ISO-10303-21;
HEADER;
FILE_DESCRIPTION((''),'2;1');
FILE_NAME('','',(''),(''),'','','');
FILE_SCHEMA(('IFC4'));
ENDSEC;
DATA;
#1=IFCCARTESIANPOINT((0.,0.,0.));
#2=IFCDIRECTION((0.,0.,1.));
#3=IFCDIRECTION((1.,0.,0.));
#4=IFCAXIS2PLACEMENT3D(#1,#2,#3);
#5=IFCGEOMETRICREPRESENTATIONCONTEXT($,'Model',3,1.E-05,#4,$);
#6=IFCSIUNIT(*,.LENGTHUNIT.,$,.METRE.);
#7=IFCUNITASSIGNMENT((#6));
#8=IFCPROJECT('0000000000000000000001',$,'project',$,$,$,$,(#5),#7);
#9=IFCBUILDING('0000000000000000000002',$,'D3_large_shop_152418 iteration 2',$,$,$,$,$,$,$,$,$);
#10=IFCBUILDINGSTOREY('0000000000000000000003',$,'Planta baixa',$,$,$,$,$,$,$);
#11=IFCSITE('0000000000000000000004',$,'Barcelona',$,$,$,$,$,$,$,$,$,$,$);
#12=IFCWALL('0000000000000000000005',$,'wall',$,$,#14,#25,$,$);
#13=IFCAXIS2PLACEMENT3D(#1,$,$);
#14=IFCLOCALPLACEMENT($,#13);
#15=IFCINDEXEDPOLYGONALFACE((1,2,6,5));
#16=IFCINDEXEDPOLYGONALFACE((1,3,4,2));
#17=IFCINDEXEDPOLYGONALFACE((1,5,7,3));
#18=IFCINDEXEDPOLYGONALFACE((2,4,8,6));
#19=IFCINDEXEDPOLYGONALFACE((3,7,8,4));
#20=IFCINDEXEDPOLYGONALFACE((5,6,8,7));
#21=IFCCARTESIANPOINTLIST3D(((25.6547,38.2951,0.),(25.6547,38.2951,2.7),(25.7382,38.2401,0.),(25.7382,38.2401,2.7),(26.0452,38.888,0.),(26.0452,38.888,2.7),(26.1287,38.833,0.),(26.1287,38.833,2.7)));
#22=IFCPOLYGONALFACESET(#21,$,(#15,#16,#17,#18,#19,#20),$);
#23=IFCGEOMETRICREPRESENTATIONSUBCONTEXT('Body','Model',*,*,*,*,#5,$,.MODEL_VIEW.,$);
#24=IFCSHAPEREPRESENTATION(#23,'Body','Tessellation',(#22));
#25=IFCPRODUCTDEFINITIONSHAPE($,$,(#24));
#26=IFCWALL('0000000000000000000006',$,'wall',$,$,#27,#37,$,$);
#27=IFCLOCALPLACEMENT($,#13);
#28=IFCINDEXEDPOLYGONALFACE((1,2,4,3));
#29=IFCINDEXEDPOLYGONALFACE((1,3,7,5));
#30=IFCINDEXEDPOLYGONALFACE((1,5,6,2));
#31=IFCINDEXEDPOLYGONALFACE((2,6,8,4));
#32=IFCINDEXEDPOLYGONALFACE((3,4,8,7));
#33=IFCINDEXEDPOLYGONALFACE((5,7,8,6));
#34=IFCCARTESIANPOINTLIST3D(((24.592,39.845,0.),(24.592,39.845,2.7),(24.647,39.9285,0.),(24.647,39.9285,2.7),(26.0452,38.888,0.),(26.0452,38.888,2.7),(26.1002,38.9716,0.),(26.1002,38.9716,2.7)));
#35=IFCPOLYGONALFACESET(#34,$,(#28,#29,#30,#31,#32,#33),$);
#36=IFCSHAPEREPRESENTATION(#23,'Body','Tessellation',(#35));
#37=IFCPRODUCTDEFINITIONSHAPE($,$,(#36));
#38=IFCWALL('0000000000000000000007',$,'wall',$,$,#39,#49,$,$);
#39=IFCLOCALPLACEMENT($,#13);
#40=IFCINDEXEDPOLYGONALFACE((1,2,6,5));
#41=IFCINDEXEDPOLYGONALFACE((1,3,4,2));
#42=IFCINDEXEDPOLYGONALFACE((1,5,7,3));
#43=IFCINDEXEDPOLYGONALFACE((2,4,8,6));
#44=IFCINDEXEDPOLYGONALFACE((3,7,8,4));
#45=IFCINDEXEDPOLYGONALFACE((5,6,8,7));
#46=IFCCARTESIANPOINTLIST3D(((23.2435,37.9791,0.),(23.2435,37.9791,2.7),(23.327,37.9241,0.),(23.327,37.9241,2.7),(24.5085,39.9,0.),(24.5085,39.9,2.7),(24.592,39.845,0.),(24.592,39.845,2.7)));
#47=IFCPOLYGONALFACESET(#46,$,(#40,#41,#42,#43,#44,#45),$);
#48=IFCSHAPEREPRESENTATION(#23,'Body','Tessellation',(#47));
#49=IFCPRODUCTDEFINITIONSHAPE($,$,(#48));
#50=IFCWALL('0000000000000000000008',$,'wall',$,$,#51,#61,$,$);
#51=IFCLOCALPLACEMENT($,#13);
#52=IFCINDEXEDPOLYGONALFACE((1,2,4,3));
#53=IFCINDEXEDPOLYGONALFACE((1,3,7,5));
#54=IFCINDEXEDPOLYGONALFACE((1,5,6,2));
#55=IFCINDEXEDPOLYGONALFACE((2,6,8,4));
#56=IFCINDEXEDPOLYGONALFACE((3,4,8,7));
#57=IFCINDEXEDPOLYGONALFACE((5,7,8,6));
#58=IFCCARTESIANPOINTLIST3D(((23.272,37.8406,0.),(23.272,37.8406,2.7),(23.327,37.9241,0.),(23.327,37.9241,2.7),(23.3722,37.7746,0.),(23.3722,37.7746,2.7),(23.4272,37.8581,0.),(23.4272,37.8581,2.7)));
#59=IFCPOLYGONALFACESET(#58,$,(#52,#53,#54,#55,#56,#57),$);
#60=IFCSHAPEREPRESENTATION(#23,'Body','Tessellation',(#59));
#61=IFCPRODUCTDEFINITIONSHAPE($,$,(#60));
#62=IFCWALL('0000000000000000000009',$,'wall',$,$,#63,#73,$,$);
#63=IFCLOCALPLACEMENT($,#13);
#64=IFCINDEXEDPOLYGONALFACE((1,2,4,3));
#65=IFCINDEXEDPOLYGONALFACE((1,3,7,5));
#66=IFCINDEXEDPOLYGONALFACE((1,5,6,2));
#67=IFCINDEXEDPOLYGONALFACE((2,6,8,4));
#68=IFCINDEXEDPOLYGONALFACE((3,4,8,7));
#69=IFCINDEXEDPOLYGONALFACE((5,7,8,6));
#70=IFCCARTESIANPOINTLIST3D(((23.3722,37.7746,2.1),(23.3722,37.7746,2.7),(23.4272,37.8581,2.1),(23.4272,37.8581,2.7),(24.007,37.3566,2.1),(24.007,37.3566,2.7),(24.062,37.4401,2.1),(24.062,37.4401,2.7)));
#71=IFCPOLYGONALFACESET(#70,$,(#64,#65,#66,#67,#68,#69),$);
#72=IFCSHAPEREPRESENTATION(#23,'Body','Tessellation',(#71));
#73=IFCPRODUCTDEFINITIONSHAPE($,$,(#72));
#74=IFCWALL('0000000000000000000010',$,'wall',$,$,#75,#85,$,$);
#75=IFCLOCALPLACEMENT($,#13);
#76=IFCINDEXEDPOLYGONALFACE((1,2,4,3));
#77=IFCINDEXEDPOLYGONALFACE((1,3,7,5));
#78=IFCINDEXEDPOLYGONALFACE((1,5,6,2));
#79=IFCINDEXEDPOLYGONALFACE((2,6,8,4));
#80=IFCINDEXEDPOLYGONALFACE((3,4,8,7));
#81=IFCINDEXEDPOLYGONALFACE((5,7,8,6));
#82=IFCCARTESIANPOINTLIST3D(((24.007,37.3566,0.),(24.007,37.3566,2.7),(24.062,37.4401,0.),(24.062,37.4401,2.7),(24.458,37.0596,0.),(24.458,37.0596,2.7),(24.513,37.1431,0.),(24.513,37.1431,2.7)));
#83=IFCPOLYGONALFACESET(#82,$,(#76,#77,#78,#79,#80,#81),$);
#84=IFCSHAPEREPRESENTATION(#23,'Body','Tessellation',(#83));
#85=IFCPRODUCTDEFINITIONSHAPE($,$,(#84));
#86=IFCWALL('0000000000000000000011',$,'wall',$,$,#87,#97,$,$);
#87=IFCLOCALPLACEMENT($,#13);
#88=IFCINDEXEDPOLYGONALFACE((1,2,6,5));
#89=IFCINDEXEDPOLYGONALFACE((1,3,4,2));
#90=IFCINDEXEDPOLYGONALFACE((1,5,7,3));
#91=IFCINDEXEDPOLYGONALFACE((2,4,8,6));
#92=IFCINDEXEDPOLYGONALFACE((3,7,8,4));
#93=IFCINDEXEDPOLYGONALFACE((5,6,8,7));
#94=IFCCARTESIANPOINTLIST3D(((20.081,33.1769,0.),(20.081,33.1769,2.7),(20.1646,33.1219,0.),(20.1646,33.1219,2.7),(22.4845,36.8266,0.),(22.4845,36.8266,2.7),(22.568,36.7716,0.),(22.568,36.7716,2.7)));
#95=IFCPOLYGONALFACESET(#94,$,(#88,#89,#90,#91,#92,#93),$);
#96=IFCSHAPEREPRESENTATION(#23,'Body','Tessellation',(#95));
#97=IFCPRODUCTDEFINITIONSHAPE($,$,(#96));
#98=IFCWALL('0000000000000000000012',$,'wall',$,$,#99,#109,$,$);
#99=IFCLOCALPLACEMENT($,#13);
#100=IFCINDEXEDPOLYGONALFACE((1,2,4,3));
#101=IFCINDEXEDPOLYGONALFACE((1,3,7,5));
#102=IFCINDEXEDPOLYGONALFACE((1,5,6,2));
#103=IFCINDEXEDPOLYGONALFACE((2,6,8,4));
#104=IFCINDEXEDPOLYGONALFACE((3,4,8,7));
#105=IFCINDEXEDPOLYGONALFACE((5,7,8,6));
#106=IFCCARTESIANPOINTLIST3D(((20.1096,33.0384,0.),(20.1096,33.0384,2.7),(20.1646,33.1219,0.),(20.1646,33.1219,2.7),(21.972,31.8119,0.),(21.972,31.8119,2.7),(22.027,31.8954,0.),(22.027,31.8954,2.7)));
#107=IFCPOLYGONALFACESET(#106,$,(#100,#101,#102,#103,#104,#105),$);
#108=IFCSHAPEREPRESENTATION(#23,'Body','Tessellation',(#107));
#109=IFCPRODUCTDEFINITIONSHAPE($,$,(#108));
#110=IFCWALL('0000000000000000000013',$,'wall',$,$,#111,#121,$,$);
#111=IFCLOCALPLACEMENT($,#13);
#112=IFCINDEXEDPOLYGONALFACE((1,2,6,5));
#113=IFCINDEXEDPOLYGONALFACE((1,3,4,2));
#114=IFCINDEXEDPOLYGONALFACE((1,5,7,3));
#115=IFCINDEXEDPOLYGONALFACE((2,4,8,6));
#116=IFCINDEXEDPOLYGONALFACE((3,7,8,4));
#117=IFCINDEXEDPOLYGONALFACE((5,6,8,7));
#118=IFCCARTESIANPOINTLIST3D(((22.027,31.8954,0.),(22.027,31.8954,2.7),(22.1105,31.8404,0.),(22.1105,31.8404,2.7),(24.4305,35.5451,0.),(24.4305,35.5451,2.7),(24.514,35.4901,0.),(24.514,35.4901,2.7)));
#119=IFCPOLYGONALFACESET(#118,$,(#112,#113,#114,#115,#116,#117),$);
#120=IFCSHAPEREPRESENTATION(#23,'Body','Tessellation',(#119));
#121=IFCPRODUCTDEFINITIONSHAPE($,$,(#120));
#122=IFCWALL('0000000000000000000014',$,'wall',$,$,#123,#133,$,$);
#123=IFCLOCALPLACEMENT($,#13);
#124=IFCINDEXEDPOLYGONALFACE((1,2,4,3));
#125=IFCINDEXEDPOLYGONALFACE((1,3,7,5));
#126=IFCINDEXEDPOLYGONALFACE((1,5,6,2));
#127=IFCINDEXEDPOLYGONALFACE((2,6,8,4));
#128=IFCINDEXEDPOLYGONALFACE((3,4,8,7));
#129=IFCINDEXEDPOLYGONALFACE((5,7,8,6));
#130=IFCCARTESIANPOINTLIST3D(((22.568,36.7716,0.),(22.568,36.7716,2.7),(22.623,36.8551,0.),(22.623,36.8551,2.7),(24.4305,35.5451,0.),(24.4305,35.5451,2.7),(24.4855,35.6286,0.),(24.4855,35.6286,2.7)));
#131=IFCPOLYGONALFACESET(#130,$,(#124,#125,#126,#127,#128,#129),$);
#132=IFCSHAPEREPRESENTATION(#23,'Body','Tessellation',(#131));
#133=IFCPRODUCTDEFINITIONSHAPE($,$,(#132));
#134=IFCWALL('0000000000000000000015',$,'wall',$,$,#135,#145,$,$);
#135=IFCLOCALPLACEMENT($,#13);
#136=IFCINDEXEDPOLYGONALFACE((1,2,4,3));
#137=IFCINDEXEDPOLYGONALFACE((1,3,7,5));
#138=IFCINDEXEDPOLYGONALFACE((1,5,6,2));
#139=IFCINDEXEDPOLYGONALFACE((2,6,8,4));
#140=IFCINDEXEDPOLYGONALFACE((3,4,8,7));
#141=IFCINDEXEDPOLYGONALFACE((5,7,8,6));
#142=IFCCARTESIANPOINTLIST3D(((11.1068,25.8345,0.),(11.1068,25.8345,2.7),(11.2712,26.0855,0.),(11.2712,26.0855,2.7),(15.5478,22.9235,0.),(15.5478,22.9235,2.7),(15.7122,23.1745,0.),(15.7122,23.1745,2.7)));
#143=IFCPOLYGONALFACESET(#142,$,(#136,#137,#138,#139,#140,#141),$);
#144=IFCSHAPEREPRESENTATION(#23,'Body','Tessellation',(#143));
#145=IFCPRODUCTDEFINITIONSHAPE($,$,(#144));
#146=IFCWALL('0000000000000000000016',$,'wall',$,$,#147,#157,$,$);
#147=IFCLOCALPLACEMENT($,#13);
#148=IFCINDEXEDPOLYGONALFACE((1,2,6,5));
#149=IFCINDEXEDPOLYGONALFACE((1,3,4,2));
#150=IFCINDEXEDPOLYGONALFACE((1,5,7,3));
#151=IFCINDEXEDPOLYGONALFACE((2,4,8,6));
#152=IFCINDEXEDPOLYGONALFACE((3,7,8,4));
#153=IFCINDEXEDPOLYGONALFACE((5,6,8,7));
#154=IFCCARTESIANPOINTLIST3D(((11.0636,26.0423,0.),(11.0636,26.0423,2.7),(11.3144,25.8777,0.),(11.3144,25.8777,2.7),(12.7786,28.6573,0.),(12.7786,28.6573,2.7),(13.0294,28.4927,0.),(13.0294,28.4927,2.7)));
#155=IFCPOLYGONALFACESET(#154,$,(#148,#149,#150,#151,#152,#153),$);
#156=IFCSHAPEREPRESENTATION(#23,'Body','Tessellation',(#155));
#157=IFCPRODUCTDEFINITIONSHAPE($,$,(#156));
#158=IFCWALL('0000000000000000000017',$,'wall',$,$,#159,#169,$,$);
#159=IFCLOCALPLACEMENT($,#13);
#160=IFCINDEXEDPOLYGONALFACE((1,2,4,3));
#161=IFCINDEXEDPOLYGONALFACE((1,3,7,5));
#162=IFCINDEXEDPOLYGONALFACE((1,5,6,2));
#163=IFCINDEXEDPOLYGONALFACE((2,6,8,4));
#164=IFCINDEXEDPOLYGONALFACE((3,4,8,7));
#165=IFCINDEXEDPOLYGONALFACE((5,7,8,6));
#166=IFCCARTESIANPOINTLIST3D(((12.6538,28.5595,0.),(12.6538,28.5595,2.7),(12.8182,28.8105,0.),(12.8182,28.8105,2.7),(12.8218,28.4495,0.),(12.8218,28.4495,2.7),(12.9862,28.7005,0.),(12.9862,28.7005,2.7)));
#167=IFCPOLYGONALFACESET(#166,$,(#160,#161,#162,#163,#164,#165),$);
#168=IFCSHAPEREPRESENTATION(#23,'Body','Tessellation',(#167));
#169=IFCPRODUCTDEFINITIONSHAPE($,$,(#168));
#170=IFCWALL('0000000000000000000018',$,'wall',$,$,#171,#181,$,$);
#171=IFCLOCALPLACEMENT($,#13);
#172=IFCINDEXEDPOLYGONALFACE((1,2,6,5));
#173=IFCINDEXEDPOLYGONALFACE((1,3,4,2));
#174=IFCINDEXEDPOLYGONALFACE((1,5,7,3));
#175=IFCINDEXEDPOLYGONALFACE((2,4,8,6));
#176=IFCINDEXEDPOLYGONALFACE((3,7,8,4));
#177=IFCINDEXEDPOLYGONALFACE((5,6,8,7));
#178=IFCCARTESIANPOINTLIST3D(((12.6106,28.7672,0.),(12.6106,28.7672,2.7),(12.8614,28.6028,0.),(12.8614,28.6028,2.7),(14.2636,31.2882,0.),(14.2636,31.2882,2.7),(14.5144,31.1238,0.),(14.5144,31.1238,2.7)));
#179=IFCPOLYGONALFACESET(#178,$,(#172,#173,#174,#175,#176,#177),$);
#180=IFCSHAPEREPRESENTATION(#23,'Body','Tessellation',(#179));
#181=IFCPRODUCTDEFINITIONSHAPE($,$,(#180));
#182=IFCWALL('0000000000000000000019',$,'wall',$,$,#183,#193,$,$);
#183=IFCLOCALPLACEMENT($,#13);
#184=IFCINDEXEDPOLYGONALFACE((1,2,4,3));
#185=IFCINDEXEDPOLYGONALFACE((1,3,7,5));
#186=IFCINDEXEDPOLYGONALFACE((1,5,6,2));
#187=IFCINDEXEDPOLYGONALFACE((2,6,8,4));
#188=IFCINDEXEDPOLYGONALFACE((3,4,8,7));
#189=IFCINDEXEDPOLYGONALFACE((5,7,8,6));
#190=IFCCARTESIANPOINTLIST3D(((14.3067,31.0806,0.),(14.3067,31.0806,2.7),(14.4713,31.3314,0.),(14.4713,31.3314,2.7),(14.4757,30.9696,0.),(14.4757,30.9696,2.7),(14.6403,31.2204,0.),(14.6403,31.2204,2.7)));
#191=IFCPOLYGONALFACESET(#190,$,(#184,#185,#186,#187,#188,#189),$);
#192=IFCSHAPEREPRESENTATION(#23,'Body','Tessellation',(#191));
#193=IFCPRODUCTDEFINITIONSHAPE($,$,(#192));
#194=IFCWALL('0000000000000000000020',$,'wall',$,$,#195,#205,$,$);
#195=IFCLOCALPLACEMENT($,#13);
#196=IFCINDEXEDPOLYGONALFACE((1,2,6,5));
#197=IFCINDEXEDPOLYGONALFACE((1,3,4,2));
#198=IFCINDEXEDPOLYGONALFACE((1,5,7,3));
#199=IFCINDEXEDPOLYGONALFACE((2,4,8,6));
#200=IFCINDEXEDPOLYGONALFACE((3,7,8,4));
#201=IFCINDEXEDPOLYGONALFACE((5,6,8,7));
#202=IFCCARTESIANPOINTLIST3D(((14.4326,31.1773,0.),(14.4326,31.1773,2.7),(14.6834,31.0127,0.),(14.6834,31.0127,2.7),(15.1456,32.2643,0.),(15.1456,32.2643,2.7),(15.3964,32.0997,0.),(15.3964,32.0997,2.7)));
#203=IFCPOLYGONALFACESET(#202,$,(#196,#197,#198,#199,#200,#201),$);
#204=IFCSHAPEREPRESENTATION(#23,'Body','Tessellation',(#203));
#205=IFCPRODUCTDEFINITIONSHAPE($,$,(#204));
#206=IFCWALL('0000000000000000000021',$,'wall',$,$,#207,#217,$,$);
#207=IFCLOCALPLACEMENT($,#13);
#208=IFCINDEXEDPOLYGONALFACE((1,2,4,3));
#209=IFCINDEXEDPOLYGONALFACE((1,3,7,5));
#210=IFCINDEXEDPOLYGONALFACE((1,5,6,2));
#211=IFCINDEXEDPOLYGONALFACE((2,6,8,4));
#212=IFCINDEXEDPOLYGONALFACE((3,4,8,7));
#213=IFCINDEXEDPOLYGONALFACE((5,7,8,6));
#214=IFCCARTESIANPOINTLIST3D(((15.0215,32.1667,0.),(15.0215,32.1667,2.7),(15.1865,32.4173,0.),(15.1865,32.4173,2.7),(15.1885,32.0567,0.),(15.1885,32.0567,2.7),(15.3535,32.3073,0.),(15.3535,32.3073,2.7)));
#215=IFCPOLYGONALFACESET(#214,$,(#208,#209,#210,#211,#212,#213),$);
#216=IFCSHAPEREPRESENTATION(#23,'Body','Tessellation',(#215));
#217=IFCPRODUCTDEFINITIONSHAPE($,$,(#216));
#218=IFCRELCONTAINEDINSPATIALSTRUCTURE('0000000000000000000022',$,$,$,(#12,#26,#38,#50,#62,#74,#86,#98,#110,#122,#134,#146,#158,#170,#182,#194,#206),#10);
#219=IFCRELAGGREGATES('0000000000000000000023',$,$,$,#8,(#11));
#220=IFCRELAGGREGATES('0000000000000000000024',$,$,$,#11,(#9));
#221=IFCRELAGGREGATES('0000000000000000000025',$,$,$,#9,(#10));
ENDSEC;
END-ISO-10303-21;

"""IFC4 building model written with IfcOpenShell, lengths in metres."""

from ifc_helpers import new_model, si_unit, frame, origin, origin_with_axes, place, context, subcontext, project, spatial, polyline, outline, extrude, element, save


model = new_model("IFC4")

# Units and contexts
model_context = context("Model", 3, precision=1e-05, world=origin_with_axes())
body_context = subcontext(model_context, "Body", "Model", "MODEL_VIEW")
ifc_project = project(units=[si_unit("LENGTHUNIT", "METRE")], contexts=[model_context])

# Site, building, storey
site = spatial("IfcSite", under=ifc_project, Name="Barcelona")
building = spatial("IfcBuilding", under=site, Name="D3_large_shop_152418 iteration 2")
storey = spatial("IfcBuildingStorey", under=building, Name="Planta baixa")

# Walls
wall_1_placement = place(None, origin_with_axes())
element("IfcWall", 1, at=wall_1_placement, inside=storey, Name="wall", context=body_context, shape_type="SweptSolid", body=[
    extrude(outline(polyline([(25.6547, 38.2951), (26.0452, 38.888), (26.1287, 38.833), (25.7382, 38.2401), (25.6547, 38.2951)])), origin(), (0.0, 0.0, 1.0), 2.7),
])
wall_2_placement = place(None, origin_with_axes())
element("IfcWall", 2, at=wall_2_placement, inside=storey, Name="wall", context=body_context, shape_type="SweptSolid", body=[
    extrude(outline(polyline([(26.0452, 38.888), (24.592, 39.845), (24.647, 39.9285), (26.1002, 38.9716), (26.0452, 38.888)])), origin(), (0.0, 0.0, 1.0), 2.7),
])
wall_3_placement = place(None, origin_with_axes())
element("IfcWall", 3, at=wall_3_placement, inside=storey, Name="wall", context=body_context, shape_type="SweptSolid", body=[
    extrude(outline(polyline([(24.592, 39.845), (23.327, 37.9241), (23.2435, 37.9791), (24.5085, 39.9), (24.592, 39.845)])), origin(), (0.0, 0.0, 1.0), 2.7),
])
wall_4_placement = place(None, origin_with_axes())
element("IfcWall", 4, at=wall_4_placement, inside=storey, Name="wall", context=body_context, shape_type="SweptSolid", body=[
    extrude(outline(polyline([(23.327, 37.9241), (23.4272, 37.8581), (23.3722, 37.7746), (23.272, 37.8406), (23.327, 37.9241)])), origin(), (0.0, 0.0, 1.0), 2.7),
])
wall_5_placement = place(None, origin_with_axes())
element("IfcWall", 5, at=wall_5_placement, inside=storey, Name="wall", context=body_context, shape_type="SweptSolid", body=[
    extrude(outline(polyline([(23.4272, 37.8581), (24.062, 37.4401), (24.007, 37.3566), (23.3722, 37.7746), (23.4272, 37.8581)])), frame((0.0, 0.0, 2.1)), (0.0, 0.0, 1.0), 0.6),
])
wall_6_placement = place(None, origin_with_axes())
element("IfcWall", 6, at=wall_6_placement, inside=storey, Name="wall", context=body_context, shape_type="SweptSolid", body=[
    extrude(outline(polyline([(24.062, 37.4401), (24.513, 37.1431), (24.458, 37.0596), (24.007, 37.3566), (24.062, 37.4401)])), origin(), (0.0, 0.0, 1.0), 2.7),
])
wall_7_placement = place(None, origin_with_axes())
element("IfcWall", 7, at=wall_7_placement, inside=storey, Name="wall", context=body_context, shape_type="SweptSolid", body=[
    extrude(outline(polyline([(22.568, 36.7716), (20.1646, 33.1219), (20.081, 33.1769), (22.4845, 36.8266), (22.568, 36.7716)])), origin(), (0.0, 0.0, 1.0), 2.7),
])
wall_8_placement = place(None, origin_with_axes())
element("IfcWall", 8, at=wall_8_placement, inside=storey, Name="wall", context=body_context, shape_type="SweptSolid", body=[
    extrude(outline(polyline([(20.1646, 33.1219), (22.027, 31.8954), (21.972, 31.8119), (20.1096, 33.0384), (20.1646, 33.1219)])), origin(), (0.0, 0.0, 1.0), 2.7),
])
wall_9_placement = place(None, origin_with_axes())
element("IfcWall", 9, at=wall_9_placement, inside=storey, Name="wall", context=body_context, shape_type="SweptSolid", body=[
    extrude(outline(polyline([(22.027, 31.8954), (24.4305, 35.5451), (24.514, 35.4901), (22.1105, 31.8404), (22.027, 31.8954)])), origin(), (0.0, 0.0, 1.0), 2.7),
])
wall_10_placement = place(None, origin_with_axes())
element("IfcWall", 10, at=wall_10_placement, inside=storey, Name="wall", context=body_context, shape_type="SweptSolid", body=[
    extrude(outline(polyline([(24.4305, 35.5451), (22.568, 36.7716), (22.623, 36.8551), (24.4855, 35.6286), (24.4305, 35.5451)])), origin(), (0.0, 0.0, 1.0), 2.7),
])
wall_11_placement = place(None, origin_with_axes())
element("IfcWall", 11, at=wall_11_placement, inside=storey, Name="wall", context=body_context, shape_type="SweptSolid", body=[
    extrude(outline(polyline([(15.5478, 22.9235), (11.1068, 25.8345), (11.2712, 26.0855), (15.7122, 23.1745), (15.5478, 22.9235)])), origin(), (0.0, 0.0, 1.0), 2.7),
])
wall_12_placement = place(None, origin_with_axes())
element("IfcWall", 12, at=wall_12_placement, inside=storey, Name="wall", context=body_context, shape_type="SweptSolid", body=[
    extrude(outline(polyline([(11.0636, 26.0423), (12.7786, 28.6573), (13.0294, 28.4927), (11.3144, 25.8777), (11.0636, 26.0423)])), origin(), (0.0, 0.0, 1.0), 2.7),
])
wall_13_placement = place(None, origin_with_axes())
element("IfcWall", 13, at=wall_13_placement, inside=storey, Name="wall", context=body_context, shape_type="SweptSolid", body=[
    extrude(outline(polyline([(12.8218, 28.4495), (12.6538, 28.5595), (12.8182, 28.8105), (12.9862, 28.7005), (12.8218, 28.4495)])), origin(), (0.0, 0.0, 1.0), 2.7),
])
wall_14_placement = place(None, origin_with_axes())
element("IfcWall", 14, at=wall_14_placement, inside=storey, Name="wall", context=body_context, shape_type="SweptSolid", body=[
    extrude(outline(polyline([(12.6106, 28.7672), (14.2636, 31.2882), (14.5144, 31.1238), (12.8614, 28.6028), (12.6106, 28.7672)])), origin(), (0.0, 0.0, 1.0), 2.7),
])
wall_15_placement = place(None, origin_with_axes())
element("IfcWall", 15, at=wall_15_placement, inside=storey, Name="wall", context=body_context, shape_type="SweptSolid", body=[
    extrude(outline(polyline([(14.4713, 31.3314), (14.6403, 31.2204), (14.4757, 30.9696), (14.3067, 31.0806), (14.4713, 31.3314)])), origin(), (0.0, 0.0, 1.0), 2.7),
])
wall_16_placement = place(None, origin_with_axes())
element("IfcWall", 16, at=wall_16_placement, inside=storey, Name="wall", context=body_context, shape_type="SweptSolid", body=[
    extrude(outline(polyline([(14.4326, 31.1773), (15.1456, 32.2643), (15.3964, 32.0997), (14.6834, 31.0127), (14.4326, 31.1773)])), origin(), (0.0, 0.0, 1.0), 2.7),
])
wall_17_placement = place(None, origin_with_axes())
element("IfcWall", 17, at=wall_17_placement, inside=storey, Name="wall", context=body_context, shape_type="SweptSolid", body=[
    extrude(outline(polyline([(15.1885, 32.0567), (15.0215, 32.1667), (15.1865, 32.4173), (15.3535, 32.3073), (15.1885, 32.0567)])), origin(), (0.0, 0.0, 1.0), 2.7),
])

save(model, "model.ifc")
